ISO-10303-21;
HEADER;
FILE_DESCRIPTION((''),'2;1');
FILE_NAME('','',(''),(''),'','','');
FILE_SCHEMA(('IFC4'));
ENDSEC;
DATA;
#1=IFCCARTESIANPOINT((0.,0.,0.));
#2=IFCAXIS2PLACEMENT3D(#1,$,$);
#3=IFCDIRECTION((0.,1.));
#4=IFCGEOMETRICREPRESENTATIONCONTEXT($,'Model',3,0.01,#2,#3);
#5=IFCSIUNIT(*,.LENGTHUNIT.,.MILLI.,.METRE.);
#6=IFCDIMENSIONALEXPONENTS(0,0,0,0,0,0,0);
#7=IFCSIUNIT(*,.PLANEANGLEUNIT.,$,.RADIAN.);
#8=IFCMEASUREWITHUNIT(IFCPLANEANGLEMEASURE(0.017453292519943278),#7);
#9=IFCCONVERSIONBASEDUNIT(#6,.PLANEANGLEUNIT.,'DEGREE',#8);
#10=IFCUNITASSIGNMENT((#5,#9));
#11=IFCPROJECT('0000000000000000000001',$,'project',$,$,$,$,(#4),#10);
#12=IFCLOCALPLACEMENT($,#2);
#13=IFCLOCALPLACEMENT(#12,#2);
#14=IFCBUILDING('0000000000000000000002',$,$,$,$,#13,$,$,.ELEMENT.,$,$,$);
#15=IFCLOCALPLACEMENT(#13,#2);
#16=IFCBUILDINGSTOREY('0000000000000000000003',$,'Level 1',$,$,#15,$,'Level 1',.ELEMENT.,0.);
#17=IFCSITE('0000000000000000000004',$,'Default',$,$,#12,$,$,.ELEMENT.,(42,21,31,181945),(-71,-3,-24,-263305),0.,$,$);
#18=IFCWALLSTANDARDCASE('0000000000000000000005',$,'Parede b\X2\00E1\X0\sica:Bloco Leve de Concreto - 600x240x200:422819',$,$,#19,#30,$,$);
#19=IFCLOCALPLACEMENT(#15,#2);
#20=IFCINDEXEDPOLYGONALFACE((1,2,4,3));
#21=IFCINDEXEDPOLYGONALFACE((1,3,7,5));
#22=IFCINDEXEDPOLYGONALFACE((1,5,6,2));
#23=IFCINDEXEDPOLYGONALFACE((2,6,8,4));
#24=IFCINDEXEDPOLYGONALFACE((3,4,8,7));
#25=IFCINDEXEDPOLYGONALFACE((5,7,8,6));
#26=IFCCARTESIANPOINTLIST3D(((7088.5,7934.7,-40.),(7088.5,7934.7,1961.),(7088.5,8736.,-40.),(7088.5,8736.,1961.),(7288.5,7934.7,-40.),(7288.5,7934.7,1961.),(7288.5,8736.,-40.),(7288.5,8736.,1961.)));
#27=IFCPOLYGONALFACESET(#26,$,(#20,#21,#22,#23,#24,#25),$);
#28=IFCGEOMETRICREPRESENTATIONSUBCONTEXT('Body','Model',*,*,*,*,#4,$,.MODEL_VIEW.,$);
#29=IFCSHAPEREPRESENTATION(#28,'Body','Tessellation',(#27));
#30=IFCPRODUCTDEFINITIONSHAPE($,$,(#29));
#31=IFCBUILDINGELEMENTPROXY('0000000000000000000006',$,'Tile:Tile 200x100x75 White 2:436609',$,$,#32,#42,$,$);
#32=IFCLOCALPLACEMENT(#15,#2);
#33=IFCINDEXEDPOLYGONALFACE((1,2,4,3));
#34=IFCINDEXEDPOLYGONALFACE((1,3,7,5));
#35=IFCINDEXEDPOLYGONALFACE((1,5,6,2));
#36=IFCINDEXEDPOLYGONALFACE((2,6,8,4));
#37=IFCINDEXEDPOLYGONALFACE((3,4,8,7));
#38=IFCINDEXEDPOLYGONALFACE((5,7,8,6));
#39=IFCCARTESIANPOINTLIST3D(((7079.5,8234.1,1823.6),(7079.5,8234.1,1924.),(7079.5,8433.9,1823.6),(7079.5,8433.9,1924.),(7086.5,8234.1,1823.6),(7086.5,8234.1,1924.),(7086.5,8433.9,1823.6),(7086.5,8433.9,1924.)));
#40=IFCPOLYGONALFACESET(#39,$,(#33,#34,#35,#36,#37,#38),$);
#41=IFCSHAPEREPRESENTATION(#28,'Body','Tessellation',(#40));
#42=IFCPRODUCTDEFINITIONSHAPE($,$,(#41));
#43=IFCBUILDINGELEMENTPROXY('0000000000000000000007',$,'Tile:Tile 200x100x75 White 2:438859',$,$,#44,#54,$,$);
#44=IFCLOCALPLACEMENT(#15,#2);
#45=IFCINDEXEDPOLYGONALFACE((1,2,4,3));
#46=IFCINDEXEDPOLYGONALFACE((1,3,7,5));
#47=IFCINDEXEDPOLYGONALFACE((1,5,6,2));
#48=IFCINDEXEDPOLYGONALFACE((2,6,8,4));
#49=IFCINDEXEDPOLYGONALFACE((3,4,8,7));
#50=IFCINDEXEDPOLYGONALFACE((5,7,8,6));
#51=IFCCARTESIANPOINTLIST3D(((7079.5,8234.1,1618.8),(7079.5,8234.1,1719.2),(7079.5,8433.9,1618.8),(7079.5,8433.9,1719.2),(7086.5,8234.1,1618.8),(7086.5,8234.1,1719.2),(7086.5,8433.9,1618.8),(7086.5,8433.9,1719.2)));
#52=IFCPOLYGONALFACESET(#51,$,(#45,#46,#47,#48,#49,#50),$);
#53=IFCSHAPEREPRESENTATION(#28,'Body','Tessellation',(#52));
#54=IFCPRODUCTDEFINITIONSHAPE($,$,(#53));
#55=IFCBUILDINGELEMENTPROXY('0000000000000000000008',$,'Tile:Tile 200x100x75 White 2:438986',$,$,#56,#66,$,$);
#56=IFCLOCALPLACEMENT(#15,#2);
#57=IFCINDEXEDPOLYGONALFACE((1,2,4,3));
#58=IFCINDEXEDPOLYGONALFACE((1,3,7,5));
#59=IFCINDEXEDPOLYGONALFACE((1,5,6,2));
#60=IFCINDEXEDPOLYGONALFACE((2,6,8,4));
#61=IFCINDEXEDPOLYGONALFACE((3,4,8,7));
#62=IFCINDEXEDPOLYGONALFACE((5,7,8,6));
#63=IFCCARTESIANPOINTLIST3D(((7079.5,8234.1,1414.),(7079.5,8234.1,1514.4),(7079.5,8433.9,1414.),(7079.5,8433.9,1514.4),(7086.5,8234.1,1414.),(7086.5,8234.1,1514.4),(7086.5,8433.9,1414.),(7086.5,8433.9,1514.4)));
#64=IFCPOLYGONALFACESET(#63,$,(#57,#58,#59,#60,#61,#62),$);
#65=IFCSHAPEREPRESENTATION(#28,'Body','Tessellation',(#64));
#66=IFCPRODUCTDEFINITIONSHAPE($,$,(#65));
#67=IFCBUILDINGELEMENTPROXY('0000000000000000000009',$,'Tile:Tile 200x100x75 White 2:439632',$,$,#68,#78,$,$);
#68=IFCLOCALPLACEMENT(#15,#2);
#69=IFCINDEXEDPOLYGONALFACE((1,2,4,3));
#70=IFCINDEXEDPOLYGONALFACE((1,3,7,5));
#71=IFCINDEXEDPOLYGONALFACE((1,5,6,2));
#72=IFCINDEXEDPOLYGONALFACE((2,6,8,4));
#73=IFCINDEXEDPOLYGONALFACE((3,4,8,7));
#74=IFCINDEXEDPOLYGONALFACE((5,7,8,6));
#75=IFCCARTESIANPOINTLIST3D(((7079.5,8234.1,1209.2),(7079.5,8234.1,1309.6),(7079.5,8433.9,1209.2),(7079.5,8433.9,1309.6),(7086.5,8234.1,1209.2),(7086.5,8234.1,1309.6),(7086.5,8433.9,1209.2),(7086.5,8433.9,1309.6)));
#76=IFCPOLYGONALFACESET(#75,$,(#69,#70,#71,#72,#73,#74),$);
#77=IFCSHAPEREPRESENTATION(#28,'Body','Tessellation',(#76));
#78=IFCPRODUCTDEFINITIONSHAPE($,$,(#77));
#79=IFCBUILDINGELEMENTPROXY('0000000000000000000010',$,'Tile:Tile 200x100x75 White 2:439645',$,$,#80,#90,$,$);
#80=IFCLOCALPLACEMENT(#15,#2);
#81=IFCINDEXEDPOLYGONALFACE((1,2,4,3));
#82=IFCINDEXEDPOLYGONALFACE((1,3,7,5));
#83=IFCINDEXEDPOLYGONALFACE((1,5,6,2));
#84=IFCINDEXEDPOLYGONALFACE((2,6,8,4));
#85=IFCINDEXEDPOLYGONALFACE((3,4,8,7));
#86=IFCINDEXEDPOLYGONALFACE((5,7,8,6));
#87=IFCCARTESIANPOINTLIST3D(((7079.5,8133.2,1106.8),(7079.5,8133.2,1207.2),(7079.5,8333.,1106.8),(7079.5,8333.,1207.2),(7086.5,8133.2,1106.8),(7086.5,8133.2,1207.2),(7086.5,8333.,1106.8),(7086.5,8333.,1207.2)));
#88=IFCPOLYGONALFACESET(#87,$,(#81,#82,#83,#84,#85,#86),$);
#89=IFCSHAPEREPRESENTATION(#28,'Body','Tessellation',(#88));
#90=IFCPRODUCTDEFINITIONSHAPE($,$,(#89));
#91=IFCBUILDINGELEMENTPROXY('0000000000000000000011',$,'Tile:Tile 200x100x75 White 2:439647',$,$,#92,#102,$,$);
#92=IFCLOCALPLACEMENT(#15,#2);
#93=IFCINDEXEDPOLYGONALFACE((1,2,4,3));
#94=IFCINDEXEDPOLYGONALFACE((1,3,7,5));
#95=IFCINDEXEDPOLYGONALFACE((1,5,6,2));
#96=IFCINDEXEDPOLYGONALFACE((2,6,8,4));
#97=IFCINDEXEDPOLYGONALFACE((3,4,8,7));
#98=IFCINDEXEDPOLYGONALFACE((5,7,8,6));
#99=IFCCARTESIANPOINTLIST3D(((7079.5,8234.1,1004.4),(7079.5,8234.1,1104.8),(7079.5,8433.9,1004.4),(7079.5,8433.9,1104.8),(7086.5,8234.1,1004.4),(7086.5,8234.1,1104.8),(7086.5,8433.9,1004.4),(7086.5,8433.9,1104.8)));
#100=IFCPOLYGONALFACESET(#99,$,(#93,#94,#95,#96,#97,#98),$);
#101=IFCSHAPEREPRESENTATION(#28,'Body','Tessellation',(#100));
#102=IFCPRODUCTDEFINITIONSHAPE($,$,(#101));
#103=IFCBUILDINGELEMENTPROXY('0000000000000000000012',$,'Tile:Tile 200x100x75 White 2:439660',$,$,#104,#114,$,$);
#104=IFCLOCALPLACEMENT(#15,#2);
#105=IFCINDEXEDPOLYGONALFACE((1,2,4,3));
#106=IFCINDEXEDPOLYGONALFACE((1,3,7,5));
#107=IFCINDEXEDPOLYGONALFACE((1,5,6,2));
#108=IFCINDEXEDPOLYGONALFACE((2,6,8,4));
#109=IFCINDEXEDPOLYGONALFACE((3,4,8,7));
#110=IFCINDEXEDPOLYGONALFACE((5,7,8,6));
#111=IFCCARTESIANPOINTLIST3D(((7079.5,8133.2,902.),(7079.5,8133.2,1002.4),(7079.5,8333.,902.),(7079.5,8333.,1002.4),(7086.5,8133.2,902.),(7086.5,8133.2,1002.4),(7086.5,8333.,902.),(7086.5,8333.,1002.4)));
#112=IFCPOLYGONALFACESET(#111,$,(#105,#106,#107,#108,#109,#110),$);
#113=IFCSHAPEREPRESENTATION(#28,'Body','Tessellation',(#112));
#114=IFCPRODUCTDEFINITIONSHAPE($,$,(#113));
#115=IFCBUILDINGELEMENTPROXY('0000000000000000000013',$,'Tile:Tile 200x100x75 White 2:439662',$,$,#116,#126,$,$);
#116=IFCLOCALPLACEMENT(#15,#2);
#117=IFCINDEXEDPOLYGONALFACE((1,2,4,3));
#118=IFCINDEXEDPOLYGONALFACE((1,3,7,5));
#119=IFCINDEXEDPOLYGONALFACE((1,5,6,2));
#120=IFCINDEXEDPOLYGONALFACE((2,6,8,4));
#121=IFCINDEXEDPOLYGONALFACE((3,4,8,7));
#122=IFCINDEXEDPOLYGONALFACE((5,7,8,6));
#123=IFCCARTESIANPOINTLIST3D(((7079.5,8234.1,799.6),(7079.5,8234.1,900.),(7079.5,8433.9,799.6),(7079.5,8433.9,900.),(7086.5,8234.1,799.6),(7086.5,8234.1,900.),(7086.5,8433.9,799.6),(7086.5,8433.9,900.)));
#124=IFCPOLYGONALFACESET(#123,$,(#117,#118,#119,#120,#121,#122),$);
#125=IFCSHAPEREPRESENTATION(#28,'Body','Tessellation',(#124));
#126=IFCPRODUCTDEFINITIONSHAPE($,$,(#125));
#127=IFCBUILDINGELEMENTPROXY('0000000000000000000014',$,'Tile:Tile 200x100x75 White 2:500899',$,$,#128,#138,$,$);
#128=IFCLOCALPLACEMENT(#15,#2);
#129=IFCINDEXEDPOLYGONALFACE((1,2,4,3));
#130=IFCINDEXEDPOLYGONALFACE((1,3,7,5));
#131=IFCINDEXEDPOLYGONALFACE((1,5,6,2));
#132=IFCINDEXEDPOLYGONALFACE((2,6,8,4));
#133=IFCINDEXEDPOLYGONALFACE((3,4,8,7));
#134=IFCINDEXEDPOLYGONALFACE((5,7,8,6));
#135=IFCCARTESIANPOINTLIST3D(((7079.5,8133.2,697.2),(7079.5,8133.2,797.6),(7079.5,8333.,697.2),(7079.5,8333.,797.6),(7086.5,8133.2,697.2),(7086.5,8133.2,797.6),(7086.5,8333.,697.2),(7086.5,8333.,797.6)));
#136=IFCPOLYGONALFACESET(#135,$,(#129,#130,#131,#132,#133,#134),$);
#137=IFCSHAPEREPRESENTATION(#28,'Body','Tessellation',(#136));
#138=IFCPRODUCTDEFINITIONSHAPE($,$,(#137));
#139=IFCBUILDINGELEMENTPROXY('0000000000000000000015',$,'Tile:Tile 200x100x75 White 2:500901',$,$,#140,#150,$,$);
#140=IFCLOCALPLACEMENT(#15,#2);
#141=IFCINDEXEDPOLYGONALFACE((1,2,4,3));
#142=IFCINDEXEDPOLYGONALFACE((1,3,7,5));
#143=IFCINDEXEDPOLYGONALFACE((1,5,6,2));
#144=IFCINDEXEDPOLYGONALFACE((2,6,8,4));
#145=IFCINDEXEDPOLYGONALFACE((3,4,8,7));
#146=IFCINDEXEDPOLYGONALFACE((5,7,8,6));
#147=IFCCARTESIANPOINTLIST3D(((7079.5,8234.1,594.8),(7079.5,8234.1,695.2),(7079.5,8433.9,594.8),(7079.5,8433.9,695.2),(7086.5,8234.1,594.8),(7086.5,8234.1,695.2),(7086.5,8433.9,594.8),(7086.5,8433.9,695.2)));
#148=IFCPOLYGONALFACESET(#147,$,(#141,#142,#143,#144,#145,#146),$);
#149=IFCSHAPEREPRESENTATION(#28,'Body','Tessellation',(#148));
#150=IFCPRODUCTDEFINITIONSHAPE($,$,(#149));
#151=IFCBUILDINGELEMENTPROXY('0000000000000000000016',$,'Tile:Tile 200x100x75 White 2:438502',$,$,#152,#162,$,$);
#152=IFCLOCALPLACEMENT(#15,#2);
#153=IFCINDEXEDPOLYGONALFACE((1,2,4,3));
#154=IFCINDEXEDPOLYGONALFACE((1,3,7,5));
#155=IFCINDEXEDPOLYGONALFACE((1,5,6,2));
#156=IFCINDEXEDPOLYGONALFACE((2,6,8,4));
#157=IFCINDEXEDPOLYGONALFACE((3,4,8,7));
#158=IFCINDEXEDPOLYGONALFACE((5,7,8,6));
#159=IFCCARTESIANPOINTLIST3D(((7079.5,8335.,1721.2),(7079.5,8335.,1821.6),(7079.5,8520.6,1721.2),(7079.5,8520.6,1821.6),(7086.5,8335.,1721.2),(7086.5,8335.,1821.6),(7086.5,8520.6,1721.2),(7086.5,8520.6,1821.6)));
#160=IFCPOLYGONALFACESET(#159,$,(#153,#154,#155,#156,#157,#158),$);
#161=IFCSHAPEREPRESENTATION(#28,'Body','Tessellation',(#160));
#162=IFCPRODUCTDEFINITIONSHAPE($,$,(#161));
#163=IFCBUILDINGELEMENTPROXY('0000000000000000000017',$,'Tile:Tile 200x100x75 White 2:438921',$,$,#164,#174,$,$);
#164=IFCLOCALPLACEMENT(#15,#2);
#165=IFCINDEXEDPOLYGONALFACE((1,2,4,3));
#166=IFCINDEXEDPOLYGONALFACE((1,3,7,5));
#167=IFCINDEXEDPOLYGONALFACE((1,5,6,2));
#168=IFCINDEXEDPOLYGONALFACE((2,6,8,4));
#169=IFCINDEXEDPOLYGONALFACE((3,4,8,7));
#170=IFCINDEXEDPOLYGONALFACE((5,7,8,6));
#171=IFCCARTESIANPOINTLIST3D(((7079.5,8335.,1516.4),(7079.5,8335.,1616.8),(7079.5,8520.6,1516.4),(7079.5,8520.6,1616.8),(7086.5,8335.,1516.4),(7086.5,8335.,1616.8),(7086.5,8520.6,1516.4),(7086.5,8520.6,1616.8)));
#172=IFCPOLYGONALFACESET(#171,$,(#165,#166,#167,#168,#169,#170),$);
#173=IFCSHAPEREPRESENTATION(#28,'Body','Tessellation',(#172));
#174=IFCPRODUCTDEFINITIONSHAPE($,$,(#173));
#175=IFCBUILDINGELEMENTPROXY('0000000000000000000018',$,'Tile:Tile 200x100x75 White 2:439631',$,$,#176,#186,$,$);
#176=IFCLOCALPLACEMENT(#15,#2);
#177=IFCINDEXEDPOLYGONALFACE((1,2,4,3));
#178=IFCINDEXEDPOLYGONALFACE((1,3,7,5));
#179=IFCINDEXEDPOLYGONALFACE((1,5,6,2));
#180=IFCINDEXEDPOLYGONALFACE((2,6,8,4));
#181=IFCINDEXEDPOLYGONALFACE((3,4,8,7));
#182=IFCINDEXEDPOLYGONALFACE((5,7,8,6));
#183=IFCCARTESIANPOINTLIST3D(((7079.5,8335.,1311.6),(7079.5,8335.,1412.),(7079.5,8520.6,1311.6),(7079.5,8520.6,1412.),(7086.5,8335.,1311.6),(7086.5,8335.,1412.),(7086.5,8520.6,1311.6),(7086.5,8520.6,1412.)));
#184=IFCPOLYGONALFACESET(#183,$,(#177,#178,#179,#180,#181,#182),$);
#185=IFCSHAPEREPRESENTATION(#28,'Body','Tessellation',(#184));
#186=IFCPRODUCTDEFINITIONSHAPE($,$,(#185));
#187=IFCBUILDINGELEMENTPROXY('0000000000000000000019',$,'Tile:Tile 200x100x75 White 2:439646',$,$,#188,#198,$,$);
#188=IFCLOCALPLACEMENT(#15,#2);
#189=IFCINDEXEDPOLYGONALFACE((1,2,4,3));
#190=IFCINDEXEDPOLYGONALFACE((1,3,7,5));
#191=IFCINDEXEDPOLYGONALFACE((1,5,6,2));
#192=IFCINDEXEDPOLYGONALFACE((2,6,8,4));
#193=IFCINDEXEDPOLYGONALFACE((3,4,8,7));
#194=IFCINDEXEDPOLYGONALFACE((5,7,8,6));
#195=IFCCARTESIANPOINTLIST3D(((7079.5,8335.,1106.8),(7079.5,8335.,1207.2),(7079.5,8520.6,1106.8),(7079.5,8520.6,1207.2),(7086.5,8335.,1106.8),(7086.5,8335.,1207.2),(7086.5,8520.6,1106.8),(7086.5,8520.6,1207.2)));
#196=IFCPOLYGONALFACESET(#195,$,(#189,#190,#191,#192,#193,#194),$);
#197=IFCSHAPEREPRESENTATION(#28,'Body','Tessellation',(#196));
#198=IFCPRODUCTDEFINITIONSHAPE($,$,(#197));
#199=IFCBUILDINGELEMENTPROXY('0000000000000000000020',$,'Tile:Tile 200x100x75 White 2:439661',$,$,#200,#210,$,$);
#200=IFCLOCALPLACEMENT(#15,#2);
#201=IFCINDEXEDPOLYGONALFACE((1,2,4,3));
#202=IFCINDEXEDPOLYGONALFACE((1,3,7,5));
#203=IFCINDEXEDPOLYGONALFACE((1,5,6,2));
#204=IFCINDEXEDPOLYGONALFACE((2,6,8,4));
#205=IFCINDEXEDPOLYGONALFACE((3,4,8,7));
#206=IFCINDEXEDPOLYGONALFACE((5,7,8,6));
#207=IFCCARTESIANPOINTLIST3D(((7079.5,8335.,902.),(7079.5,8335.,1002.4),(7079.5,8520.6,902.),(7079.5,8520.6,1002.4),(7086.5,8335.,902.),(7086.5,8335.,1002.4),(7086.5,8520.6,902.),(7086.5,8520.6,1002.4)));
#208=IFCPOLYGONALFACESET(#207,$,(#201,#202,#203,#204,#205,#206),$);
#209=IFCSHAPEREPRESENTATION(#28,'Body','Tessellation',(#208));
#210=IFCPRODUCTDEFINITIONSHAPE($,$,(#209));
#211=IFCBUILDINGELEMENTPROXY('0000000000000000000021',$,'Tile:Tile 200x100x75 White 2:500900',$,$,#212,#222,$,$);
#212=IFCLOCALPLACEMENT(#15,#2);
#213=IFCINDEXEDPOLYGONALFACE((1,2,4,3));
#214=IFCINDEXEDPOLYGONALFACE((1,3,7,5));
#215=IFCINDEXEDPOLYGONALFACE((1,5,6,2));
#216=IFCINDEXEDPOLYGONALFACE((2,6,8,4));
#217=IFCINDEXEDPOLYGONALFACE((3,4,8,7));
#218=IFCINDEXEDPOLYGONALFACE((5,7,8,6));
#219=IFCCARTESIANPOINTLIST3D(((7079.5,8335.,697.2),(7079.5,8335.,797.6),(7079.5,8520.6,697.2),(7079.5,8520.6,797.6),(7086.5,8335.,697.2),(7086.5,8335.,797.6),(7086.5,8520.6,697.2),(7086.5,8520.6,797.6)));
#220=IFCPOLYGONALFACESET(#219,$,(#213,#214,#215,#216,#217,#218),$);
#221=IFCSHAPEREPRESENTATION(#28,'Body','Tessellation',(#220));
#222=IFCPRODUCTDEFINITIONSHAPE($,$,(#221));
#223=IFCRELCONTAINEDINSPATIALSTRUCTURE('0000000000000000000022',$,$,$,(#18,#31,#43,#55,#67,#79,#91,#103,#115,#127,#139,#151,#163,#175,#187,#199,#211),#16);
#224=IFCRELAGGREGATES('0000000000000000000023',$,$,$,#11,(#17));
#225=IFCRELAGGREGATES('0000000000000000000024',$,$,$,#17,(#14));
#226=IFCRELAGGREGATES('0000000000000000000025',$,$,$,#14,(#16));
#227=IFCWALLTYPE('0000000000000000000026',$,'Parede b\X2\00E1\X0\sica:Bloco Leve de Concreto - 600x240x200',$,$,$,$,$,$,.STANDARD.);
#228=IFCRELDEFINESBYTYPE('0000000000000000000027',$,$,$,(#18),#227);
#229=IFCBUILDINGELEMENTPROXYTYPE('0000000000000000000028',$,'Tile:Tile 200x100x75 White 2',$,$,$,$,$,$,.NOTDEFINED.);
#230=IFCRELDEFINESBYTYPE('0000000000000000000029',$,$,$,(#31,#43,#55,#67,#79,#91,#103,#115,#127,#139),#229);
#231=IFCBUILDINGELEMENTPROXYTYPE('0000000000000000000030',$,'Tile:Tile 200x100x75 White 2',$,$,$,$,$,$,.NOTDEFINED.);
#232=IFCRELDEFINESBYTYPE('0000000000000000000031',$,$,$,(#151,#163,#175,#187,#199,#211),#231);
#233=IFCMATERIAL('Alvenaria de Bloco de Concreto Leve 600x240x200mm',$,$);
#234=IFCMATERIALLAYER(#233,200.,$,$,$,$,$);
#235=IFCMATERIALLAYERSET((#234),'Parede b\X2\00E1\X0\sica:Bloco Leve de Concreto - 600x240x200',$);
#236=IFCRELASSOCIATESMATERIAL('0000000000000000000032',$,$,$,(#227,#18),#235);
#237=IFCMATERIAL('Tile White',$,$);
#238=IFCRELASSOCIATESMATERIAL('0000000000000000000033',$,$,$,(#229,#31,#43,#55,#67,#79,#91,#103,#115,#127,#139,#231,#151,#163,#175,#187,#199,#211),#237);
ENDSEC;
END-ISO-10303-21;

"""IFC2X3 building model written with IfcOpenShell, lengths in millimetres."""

from ifc_helpers import new_model, entity, si_unit, converted_unit, direction, frame, frame_2d, origin, place, context, subcontext, project, spatial, rectangle, extrude, source, transform, mapped, material, layer, layer_set, layer_usage, type_object, type_shapes, element, save


model = new_model("IFC2X3")

# Units and contexts
model_context = context("Model", 3, precision=0.01, world=origin(), true_north=direction((0.0, 1.0)))
body_context = subcontext(model_context, "Body", "Model", "MODEL_VIEW")
ifc_project = project(units=[si_unit("LENGTHUNIT", "METRE", prefix="MILLI"), converted_unit("PLANEANGLEUNIT", "DEGREE", entity("IfcPlaneAngleMeasure", 0.017453292519943278), si_unit("PLANEANGLEUNIT", "RADIAN"), dimensions=[0, 0, 0, 0, 0, 0, 0])], contexts=[model_context])

# Site, building, storey
site_placement = place(None, origin())
site = spatial("IfcSite", under=ifc_project, at=site_placement, Name="Default", CompositionType="ELEMENT", RefLatitude=(42, 21, 31, 181945), RefLongitude=(-71, -3, -24, -263305), RefElevation=0.0)
building_placement = place(site_placement, origin())
building = spatial("IfcBuilding", under=site, at=building_placement, CompositionType="ELEMENT")
storey_placement = place(building_placement, origin())
storey = spatial("IfcBuildingStorey", under=building, at=storey_placement, Name="Level 1", LongName="Level 1", CompositionType="ELEMENT", Elevation=0.0)

# Wall
ifc_material_1 = material(Name="Alvenaria de Bloco de Concreto Leve 600x240x200mm")
ifc_layer = layer(ifc_material_1, 200.0)
ifc_layer_set = layer_set([ifc_layer], Name="Parede básica:Bloco Leve de Concreto - 600x240x200")
ifc_layer_usage = layer_usage(ifc_layer_set, "AXIS2", "NEGATIVE", 100.0)
wall_type = type_object("IfcWallType", Name="Parede básica:Bloco Leve de Concreto - 600x240x200", PredefinedType="STANDARD", material=ifc_layer_set)
wall_placement = place(storey_placement, frame((7188.5, 8736.0, -40.0), z_axis=(0.0, 0.0, 1.0), x_axis=(0.0, -1.0, 0.0)))
element("IfcWallStandardCase", 1, at=wall_placement, inside=storey, type_object=wall_type, material=ifc_layer_usage, Name="Parede básica:Bloco Leve de Concreto - 600x240x200:422819", context=body_context, shape_type="SweptSolid", body=[
    extrude(rectangle(XDim=801.4, YDim=200.0, at=frame_2d((400.7, 0.0), x_axis=(-1.0, 0.0))), origin(), (0.0, 0.0, 1.0), 2001.0),
])

# Building element proxies
ifc_material_2 = material(Name="Tile White")
building_element_proxy_type_1 = type_object("IfcBuildingElementProxyType", Name="Tile:Tile 200x100x75 White 2", PredefinedType="NOTDEFINED", material=ifc_material_2)
shared_shape_1 = source(origin(), body_context, "Body", "SweptSolid", [
    extrude(rectangle(XDim=199.8, YDim=100.4, at=frame_2d((0.0, 0.0), x_axis=(1.0, 0.0))), frame((-50.2, -99.9, 0.0), z_axis=(0.0, 0.0, 1.0), x_axis=(0.0, -1.0, 0.0)), (0.0, 0.0, 1.0), 7.0),
])
type_shapes(building_element_proxy_type_1, [shared_shape_1])
for number, where, z_axis, x_axis, name in (
    (2, (7086.5, 8433.9, 1924.0), (-1.0, 0.0, 0.0), (0.0, 0.0, 1.0), "Tile:Tile 200x100x75 White 2:436609"),
    (3, (7086.5, 8433.9, 1719.2), (-1.0, 0.0, 0.0), (0.0, 0.0, 1.0), "Tile:Tile 200x100x75 White 2:438859"),
    (4, (7086.5, 8433.9, 1514.4), (-1.0, 0.0, 0.0), (0.0, 0.0, 1.0), "Tile:Tile 200x100x75 White 2:438986"),
    (5, (7086.5, 8433.9, 1309.6), (-1.0, 0.0, 0.0), (0.0, 0.0, 1.0), "Tile:Tile 200x100x75 White 2:439632"),
    (6, (7086.5, 8333.0, 1207.2), (-1.0, 0.0, 0.0), (0.0, 0.0, 1.0), "Tile:Tile 200x100x75 White 2:439645"),
    (7, (7086.5, 8433.9, 1104.8), (-1.0, 0.0, 0.0), (0.0, 0.0, 1.0), "Tile:Tile 200x100x75 White 2:439647"),
    (8, (7086.5, 8333.0, 1002.4), (-1.0, 0.0, 0.0), (0.0, 0.0, 1.0), "Tile:Tile 200x100x75 White 2:439660"),
    (9, (7086.5, 8433.9, 900.0), (-1.0, 0.0, 0.0), (0.0, 0.0, 1.0), "Tile:Tile 200x100x75 White 2:439662"),
    (10, (7086.5, 8333.0, 797.6), (-1.0, 0.0, 0.0), (0.0, 0.0, 1.0), "Tile:Tile 200x100x75 White 2:500899"),
    (11, (7086.5, 8433.9, 695.2), (-1.0, 0.0, 0.0), (0.0, 0.0, 1.0), "Tile:Tile 200x100x75 White 2:500901"),
):
    element("IfcBuildingElementProxy", number, at=place(storey_placement, frame(where, z_axis=z_axis, x_axis=x_axis)), inside=storey, type_object=building_element_proxy_type_1, material=ifc_material_2, Name=name, context=body_context, shape_type="MappedRepresentation", body=[
        mapped(shared_shape_1, transform((0.0, 0.0, 0.0), scale=1.0)),
    ])
building_element_proxy_type_2 = type_object("IfcBuildingElementProxyType", Name="Tile:Tile 200x100x75 White 2", PredefinedType="NOTDEFINED", material=ifc_material_2)
shared_shape_2 = source(origin(), body_context, "Body", "SweptSolid", [
    extrude(rectangle(XDim=185.6, YDim=100.4, at=frame_2d((0.0, 0.0), x_axis=(1.0, 0.0))), frame((-50.2, -92.8, 0.0), z_axis=(0.0, 0.0, 1.0), x_axis=(0.0, -1.0, 0.0)), (0.0, 0.0, 1.0), 7.0),
])
type_shapes(building_element_proxy_type_2, [shared_shape_2])
for number, where, z_axis, x_axis, name in (
    (12, (7086.5, 8520.6, 1821.6), (-1.0, 0.0, 0.0), (0.0, 0.0, 1.0), "Tile:Tile 200x100x75 White 2:438502"),
    (13, (7086.5, 8520.6, 1616.8), (-1.0, 0.0, 0.0), (0.0, 0.0, 1.0), "Tile:Tile 200x100x75 White 2:438921"),
    (14, (7086.5, 8520.6, 1412.0), (-1.0, 0.0, 0.0), (0.0, 0.0, 1.0), "Tile:Tile 200x100x75 White 2:439631"),
    (15, (7086.5, 8520.6, 1207.2), (-1.0, 0.0, 0.0), (0.0, 0.0, 1.0), "Tile:Tile 200x100x75 White 2:439646"),
    (16, (7086.5, 8520.6, 1002.4), (-1.0, 0.0, 0.0), (0.0, 0.0, 1.0), "Tile:Tile 200x100x75 White 2:439661"),
    (17, (7086.5, 8520.6, 797.6), (-1.0, 0.0, 0.0), (0.0, 0.0, 1.0), "Tile:Tile 200x100x75 White 2:500900"),
):
    element("IfcBuildingElementProxy", number, at=place(storey_placement, frame(where, z_axis=z_axis, x_axis=x_axis)), inside=storey, type_object=building_element_proxy_type_2, material=ifc_material_2, Name=name, context=body_context, shape_type="MappedRepresentation", body=[
        mapped(shared_shape_2, transform((0.0, 0.0, 0.0), scale=1.0)),
    ])

save(model, "model.ifc")
